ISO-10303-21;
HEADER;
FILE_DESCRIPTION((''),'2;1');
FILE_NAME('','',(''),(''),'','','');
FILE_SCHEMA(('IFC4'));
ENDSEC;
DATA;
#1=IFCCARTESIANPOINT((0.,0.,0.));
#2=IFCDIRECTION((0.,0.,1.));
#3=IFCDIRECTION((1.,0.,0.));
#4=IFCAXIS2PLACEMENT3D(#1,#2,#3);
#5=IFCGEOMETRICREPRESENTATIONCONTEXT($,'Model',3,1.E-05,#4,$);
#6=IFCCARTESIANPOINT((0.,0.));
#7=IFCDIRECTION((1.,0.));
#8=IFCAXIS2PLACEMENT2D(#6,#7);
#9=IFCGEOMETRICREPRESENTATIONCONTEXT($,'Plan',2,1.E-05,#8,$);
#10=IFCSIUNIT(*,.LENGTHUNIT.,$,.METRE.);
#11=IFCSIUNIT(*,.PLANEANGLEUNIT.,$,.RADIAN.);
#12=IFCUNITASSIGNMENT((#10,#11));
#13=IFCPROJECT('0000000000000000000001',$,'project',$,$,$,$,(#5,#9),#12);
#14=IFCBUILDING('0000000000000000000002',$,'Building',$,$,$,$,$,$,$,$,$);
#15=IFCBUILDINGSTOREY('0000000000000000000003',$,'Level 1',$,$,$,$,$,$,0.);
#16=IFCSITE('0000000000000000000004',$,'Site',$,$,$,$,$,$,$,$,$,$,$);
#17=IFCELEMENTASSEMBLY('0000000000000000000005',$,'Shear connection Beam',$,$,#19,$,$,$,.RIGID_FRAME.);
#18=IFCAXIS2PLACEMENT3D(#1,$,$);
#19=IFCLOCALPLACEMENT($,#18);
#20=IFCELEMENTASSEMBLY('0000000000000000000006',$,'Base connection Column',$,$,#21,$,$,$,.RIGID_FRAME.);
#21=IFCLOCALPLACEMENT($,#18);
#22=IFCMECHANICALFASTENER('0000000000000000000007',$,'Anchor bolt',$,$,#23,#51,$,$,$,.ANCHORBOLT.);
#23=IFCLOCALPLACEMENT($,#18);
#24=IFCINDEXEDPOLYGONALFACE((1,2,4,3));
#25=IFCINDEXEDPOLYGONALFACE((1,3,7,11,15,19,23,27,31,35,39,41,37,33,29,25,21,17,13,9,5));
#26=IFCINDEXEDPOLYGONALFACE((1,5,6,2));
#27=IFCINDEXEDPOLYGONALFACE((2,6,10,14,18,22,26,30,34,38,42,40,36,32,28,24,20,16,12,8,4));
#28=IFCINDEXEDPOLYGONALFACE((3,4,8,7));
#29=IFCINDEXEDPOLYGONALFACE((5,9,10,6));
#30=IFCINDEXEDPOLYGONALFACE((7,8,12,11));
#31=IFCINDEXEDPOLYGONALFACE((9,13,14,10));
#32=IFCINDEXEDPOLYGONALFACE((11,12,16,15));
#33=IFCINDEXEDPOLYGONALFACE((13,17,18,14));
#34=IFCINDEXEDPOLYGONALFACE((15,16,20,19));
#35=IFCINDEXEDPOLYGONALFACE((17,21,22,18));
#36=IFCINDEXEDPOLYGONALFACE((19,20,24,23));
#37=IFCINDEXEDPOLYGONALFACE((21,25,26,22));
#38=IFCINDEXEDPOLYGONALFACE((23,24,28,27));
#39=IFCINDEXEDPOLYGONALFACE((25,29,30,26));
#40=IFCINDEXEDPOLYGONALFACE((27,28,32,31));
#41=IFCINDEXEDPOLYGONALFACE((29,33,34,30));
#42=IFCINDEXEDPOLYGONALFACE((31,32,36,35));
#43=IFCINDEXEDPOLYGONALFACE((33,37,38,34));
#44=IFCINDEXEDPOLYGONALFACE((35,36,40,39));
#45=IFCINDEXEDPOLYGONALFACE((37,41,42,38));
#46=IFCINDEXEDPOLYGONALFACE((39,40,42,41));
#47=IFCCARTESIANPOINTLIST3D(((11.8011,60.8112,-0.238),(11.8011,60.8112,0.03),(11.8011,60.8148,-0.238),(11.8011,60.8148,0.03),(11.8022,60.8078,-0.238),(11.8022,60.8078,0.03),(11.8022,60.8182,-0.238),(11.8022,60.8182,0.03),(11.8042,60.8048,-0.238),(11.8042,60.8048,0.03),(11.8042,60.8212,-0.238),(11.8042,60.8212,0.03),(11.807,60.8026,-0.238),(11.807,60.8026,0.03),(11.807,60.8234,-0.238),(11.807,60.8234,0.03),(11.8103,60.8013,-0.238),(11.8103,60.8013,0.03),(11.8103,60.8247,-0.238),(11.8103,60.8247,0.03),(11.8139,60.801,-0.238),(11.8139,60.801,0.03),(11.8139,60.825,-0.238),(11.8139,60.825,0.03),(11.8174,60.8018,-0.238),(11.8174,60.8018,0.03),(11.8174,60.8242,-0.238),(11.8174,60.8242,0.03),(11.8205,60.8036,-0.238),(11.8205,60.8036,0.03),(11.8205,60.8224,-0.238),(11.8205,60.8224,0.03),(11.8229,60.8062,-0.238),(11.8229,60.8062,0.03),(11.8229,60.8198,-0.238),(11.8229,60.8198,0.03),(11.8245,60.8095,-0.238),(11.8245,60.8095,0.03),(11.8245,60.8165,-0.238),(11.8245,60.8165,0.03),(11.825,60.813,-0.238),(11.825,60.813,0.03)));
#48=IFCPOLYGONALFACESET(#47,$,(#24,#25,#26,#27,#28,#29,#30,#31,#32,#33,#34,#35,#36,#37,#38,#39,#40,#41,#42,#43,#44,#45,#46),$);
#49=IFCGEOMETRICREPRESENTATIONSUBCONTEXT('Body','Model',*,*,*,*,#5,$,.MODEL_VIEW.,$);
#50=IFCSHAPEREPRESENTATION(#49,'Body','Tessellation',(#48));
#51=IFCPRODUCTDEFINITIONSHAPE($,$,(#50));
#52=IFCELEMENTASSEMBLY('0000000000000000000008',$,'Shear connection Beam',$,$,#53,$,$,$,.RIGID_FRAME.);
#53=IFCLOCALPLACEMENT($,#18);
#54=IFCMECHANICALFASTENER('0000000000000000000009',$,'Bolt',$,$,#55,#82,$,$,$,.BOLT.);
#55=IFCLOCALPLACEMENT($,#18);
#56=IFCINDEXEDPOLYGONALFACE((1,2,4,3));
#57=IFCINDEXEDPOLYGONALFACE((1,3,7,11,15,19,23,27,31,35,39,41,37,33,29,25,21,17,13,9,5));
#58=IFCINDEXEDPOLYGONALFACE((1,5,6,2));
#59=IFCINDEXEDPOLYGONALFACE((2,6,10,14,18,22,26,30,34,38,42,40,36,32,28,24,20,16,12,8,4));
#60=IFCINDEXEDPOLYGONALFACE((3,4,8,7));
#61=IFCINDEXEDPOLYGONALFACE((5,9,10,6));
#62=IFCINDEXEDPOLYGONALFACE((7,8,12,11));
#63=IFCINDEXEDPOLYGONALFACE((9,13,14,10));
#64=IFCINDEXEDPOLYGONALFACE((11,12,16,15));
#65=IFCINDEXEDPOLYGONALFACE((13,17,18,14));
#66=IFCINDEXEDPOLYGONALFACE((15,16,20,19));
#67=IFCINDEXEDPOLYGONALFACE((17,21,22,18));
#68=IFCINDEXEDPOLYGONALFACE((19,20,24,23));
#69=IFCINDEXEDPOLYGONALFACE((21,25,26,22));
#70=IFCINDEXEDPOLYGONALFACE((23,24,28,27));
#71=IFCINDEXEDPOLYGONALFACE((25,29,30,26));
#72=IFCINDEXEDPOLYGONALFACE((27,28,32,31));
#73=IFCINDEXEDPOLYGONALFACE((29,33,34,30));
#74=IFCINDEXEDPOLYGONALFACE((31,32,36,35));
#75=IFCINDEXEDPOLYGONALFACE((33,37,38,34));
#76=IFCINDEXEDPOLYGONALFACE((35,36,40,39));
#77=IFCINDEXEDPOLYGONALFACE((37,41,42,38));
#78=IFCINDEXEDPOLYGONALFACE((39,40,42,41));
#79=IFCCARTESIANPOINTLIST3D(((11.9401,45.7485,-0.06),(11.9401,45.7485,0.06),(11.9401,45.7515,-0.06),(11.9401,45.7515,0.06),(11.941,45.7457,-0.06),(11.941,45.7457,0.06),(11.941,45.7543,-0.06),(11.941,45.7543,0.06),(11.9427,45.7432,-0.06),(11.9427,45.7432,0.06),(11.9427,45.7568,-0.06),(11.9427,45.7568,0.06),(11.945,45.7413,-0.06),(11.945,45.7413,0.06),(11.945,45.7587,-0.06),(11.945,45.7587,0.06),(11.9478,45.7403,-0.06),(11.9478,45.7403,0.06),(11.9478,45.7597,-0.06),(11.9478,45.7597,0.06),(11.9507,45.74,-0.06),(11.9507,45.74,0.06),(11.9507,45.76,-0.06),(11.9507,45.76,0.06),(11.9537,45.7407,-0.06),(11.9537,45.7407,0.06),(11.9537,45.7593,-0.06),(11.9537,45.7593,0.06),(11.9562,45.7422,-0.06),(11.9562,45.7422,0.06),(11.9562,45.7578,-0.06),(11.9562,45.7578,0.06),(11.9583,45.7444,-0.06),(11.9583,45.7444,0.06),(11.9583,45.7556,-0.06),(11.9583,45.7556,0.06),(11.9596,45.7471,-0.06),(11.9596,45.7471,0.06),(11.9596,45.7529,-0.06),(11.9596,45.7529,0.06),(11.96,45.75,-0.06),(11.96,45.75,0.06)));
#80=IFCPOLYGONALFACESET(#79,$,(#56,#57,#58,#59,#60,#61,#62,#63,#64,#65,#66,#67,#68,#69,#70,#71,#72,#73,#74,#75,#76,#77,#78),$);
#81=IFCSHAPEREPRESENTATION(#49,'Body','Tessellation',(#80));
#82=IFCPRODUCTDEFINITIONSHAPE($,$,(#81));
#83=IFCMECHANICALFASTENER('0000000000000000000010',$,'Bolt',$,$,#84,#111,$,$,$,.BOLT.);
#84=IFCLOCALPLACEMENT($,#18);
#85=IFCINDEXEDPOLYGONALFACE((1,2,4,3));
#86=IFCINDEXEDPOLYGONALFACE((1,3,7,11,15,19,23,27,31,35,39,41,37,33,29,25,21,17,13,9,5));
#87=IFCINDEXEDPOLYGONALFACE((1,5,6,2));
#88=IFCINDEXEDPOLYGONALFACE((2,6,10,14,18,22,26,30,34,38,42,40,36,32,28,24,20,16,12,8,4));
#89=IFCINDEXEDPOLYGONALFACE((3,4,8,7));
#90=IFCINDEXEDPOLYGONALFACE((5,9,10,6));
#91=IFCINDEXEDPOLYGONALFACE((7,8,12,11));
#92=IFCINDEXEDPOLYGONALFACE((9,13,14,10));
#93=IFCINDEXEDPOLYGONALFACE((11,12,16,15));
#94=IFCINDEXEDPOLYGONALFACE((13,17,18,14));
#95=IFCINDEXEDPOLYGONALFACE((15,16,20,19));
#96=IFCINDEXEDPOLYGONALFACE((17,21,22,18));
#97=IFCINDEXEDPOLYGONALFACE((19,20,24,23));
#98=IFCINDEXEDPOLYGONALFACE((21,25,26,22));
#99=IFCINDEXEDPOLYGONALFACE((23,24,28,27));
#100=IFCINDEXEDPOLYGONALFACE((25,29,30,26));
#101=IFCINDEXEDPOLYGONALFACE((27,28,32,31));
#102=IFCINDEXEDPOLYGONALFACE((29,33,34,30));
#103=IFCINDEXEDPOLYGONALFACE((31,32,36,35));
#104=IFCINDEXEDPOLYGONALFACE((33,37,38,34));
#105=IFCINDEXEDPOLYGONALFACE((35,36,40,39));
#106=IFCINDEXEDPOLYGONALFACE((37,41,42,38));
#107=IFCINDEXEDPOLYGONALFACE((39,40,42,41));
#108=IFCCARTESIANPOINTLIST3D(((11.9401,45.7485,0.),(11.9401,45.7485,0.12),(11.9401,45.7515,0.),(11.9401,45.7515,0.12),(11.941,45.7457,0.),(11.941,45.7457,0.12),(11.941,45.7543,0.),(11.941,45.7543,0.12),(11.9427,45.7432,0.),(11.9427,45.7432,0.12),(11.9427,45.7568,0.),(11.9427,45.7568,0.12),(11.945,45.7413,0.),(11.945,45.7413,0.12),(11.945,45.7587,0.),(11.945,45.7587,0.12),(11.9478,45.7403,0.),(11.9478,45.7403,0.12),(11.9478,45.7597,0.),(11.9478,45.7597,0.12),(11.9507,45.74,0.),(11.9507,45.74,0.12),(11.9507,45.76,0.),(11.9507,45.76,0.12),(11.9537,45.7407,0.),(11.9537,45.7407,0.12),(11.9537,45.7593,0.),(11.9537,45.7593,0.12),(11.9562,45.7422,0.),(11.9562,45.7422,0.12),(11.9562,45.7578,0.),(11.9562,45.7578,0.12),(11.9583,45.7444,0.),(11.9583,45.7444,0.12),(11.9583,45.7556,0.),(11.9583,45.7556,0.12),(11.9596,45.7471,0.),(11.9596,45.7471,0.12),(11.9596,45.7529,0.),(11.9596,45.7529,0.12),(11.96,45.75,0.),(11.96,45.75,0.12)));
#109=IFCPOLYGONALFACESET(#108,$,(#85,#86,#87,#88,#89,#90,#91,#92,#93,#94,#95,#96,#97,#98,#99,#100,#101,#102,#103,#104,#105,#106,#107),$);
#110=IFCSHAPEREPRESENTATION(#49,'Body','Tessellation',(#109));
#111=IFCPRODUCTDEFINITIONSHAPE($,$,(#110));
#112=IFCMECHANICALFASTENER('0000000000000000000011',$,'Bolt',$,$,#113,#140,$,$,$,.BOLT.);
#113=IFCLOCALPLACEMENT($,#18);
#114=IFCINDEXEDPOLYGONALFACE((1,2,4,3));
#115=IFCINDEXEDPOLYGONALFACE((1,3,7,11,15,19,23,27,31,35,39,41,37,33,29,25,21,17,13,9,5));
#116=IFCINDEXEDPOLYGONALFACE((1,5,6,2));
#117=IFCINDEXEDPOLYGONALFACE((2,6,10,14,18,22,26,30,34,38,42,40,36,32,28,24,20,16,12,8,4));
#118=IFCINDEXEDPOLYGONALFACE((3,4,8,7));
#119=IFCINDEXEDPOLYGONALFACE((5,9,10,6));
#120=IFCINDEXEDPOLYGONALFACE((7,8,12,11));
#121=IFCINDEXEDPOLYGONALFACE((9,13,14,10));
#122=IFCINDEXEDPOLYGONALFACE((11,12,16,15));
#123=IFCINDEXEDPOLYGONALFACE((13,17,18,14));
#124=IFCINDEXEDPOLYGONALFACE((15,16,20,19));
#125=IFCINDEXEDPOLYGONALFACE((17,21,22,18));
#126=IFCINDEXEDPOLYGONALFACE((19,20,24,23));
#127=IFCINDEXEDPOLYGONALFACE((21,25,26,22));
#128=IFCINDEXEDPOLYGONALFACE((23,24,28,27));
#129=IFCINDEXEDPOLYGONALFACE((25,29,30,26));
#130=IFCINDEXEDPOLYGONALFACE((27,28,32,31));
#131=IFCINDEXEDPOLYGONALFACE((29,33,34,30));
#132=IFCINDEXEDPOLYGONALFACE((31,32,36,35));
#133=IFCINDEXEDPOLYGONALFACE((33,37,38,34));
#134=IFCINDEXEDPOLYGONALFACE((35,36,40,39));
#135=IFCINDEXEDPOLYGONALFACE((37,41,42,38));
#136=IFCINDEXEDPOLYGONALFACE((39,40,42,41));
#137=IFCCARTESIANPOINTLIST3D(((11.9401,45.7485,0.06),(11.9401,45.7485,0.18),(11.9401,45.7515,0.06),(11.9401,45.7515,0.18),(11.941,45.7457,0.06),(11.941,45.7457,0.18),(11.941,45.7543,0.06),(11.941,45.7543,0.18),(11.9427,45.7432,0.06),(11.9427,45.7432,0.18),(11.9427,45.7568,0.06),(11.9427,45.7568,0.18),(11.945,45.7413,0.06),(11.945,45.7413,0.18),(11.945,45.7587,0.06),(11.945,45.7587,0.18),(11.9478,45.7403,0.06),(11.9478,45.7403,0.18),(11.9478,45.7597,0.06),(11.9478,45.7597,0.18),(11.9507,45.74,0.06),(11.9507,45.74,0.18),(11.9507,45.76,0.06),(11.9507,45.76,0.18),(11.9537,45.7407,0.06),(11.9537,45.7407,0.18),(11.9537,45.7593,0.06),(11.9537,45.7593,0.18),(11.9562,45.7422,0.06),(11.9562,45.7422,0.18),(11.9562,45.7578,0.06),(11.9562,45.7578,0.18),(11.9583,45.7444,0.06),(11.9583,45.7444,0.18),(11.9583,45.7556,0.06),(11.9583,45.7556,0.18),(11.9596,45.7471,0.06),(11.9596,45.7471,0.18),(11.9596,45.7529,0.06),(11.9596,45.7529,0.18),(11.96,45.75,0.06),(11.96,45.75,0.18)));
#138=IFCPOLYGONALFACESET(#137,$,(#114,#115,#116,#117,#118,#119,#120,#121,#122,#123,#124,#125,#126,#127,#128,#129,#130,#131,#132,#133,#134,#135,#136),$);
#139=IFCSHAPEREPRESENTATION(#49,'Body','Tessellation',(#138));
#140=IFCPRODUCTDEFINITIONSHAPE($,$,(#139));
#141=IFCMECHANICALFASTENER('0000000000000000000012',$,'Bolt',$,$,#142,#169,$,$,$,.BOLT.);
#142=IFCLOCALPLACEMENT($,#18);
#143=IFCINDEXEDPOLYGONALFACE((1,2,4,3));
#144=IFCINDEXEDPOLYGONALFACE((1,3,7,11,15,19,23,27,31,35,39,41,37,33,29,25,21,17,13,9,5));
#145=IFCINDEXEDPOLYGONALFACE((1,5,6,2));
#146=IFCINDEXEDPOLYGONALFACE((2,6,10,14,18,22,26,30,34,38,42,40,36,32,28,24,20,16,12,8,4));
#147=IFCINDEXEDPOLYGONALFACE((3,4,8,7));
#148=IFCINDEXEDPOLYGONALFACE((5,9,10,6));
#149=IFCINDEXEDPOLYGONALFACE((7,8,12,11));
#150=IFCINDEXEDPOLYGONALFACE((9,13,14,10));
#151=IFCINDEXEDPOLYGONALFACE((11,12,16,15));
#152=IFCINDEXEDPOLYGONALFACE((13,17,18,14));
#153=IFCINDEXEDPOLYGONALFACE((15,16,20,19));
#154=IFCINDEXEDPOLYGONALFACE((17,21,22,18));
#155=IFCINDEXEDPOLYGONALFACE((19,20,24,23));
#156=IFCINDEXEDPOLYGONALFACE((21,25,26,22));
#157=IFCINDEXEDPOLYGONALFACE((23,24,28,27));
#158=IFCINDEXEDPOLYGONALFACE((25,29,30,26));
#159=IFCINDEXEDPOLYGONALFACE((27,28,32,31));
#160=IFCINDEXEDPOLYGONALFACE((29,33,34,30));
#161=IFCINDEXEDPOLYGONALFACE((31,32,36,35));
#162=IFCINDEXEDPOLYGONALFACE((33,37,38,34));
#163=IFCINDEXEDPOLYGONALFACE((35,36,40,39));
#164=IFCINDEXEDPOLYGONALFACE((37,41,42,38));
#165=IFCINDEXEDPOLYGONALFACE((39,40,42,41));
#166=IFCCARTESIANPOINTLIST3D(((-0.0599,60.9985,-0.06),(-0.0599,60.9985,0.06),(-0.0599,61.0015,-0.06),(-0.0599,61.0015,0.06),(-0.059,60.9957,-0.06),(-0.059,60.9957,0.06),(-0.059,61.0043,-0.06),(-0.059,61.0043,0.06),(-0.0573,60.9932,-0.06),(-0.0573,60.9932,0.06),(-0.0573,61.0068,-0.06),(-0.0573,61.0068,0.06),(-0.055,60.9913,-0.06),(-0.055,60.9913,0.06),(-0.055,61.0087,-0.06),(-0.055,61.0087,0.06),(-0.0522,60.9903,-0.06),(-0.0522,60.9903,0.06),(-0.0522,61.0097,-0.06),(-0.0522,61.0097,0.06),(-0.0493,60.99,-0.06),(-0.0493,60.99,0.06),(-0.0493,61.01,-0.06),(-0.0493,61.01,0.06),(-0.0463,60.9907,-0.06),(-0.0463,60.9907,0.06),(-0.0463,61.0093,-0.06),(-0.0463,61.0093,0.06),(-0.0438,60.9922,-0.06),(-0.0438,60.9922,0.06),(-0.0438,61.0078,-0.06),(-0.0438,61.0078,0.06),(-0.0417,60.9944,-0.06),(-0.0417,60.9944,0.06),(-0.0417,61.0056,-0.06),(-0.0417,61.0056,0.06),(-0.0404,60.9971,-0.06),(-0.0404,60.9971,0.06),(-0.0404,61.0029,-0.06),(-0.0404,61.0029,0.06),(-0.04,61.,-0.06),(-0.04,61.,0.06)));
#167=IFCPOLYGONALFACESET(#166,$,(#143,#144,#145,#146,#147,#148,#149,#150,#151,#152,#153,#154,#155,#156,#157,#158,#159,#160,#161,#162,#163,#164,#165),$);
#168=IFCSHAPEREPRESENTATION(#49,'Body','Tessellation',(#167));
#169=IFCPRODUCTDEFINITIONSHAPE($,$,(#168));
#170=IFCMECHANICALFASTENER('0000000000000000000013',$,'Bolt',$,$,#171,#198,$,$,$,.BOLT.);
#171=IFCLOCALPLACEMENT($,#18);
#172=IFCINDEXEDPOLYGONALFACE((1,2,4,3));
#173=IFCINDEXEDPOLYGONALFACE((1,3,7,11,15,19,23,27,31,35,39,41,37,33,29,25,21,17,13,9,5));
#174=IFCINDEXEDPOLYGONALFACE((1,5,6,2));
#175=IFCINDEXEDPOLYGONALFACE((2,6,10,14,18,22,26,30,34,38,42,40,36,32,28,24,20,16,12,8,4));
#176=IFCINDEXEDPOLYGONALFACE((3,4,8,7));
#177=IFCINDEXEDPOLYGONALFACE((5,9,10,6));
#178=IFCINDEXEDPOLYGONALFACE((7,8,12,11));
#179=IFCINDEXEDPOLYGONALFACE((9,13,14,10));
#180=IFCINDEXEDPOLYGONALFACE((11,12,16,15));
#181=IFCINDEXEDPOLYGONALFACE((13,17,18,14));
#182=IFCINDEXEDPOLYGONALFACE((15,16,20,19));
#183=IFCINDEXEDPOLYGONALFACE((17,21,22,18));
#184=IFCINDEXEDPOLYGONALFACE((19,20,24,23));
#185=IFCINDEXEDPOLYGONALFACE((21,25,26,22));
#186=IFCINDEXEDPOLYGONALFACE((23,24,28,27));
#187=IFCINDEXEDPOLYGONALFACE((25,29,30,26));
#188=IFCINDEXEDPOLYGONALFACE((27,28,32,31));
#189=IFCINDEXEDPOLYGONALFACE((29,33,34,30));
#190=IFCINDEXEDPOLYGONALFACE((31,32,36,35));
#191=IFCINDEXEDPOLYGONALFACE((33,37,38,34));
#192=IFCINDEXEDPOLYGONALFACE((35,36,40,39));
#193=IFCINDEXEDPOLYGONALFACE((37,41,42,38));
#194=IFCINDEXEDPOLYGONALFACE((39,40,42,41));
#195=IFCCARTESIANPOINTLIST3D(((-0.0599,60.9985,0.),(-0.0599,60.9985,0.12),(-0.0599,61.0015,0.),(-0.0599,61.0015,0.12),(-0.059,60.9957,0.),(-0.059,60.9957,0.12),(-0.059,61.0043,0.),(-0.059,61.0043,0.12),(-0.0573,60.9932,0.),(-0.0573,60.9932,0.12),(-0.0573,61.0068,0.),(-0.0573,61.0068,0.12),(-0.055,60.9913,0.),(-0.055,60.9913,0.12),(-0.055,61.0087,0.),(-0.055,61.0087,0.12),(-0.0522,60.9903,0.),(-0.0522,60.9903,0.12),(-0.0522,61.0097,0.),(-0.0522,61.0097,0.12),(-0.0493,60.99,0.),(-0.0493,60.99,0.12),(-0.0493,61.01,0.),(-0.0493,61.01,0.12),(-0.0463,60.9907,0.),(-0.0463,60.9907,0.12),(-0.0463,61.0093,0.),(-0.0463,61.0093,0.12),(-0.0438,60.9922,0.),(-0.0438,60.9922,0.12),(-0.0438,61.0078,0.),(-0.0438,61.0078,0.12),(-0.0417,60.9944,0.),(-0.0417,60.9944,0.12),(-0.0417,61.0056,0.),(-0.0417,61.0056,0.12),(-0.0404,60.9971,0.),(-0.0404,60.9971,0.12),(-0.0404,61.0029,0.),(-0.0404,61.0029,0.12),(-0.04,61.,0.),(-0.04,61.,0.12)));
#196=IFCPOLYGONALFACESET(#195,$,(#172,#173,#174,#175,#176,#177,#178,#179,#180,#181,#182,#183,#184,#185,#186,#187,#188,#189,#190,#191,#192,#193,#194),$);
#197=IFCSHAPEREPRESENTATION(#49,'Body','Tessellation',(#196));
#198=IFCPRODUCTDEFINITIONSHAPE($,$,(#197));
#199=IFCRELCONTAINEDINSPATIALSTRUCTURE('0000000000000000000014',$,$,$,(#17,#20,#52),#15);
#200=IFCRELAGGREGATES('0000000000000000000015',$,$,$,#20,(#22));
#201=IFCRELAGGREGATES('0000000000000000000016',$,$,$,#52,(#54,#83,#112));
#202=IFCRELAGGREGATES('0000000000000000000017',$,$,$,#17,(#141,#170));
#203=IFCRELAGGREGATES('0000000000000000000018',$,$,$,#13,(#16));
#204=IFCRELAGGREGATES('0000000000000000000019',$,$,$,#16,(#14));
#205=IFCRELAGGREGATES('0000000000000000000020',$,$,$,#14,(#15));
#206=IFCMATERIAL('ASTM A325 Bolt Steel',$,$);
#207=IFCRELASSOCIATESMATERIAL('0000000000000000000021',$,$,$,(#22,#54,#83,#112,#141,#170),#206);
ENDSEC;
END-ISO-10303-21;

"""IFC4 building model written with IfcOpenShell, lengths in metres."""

from ifc_helpers import new_model, si_unit, frame, origin_with_axes, origin_2d, origin_2d_with_axis, place, context, subcontext, project, spatial, circle, extrude, material, element, aggregate, save


model = new_model("IFC4")

# Units and contexts
model_context = context("Model", 3, precision=1e-05, world=origin_with_axes())
plan_context = context("Plan", 2, precision=1e-05, world=origin_2d_with_axis())
body_context = subcontext(model_context, "Body", "Model", "MODEL_VIEW")
ifc_project = project(units=[si_unit("LENGTHUNIT", "METRE"), si_unit("PLANEANGLEUNIT", "RADIAN")], contexts=[model_context, plan_context])

# Site, building, storey
site = spatial("IfcSite", under=ifc_project, Name="Site")
building = spatial("IfcBuilding", under=site, Name="Building")
storey = spatial("IfcBuildingStorey", under=building, Name="Level 1", Elevation=0.0)

# Element assembly
assembly_1 = element("IfcElementAssembly", 1, inside=storey, Name="Shear connection Beam", PredefinedType="RIGID_FRAME")

# Shared definitions
ifc_material_1 = material(Name="ASTM A325 Bolt Steel")

# Element assemblies, mechanical fasteners
assembly_2 = element("IfcElementAssembly", 2, inside=storey, Name="Base connection Column", PredefinedType="RIGID_FRAME")
mechanical_fastener_1_placement = place(None, frame((11.813, 60.813, -0.238), z_axis=(0.0, 0.0, 1.0), x_axis=(1.0, 0.0, 0.0)))
mechanical_fastener_1 = element("IfcMechanicalFastener", 3, at=mechanical_fastener_1_placement, material=ifc_material_1, Name="Anchor bolt", PredefinedType="ANCHORBOLT", context=body_context, shape_type="SweptSolid", body=[
    extrude(circle(Radius=0.012, at=origin_2d()), origin_with_axes(), (0.0, 0.0, 1.0), 0.268),
])
aggregate(assembly_2, [mechanical_fastener_1])
assembly_3 = element("IfcElementAssembly", 4, inside=storey, Name="Shear connection Beam", PredefinedType="RIGID_FRAME")
mechanical_fastener_2_placement = place(None, frame((11.95, 45.75, -0.06), z_axis=(0.0, 0.0, 1.0), x_axis=(1.0, 0.0, 0.0)))
mechanical_fastener_2 = element("IfcMechanicalFastener", 5, at=mechanical_fastener_2_placement, material=ifc_material_1, Name="Bolt", PredefinedType="BOLT", context=body_context, shape_type="SweptSolid", body=[
    extrude(circle(Radius=0.01, at=origin_2d()), origin_with_axes(), (0.0, 0.0, 1.0), 0.12),
])
mechanical_fastener_3_placement = place(None, frame((11.95, 45.75, 0.0), z_axis=(0.0, 0.0, 1.0), x_axis=(1.0, 0.0, 0.0)))
mechanical_fastener_3 = element("IfcMechanicalFastener", 6, at=mechanical_fastener_3_placement, material=ifc_material_1, Name="Bolt", PredefinedType="BOLT", context=body_context, shape_type="SweptSolid", body=[
    extrude(circle(Radius=0.01, at=origin_2d()), origin_with_axes(), (0.0, 0.0, 1.0), 0.12),
])
mechanical_fastener_4_placement = place(None, frame((11.95, 45.75, 0.06), z_axis=(0.0, 0.0, 1.0), x_axis=(1.0, 0.0, 0.0)))
mechanical_fastener_4 = element("IfcMechanicalFastener", 7, at=mechanical_fastener_4_placement, material=ifc_material_1, Name="Bolt", PredefinedType="BOLT", context=body_context, shape_type="SweptSolid", body=[
    extrude(circle(Radius=0.01, at=origin_2d()), origin_with_axes(), (0.0, 0.0, 1.0), 0.12),
])
aggregate(assembly_3, [mechanical_fastener_2, mechanical_fastener_3, mechanical_fastener_4])

# Mechanical fasteners
mechanical_fastener_5_placement = place(None, frame((-0.05, 61.0, -0.06), z_axis=(0.0, 0.0, 1.0), x_axis=(1.0, 0.0, 0.0)))
mechanical_fastener_5 = element("IfcMechanicalFastener", 8, at=mechanical_fastener_5_placement, material=ifc_material_1, Name="Bolt", PredefinedType="BOLT", context=body_context, shape_type="SweptSolid", body=[
    extrude(circle(Radius=0.01, at=origin_2d()), origin_with_axes(), (0.0, 0.0, 1.0), 0.12),
])
mechanical_fastener_6_placement = place(None, frame((-0.05, 61.0, 0.0), z_axis=(0.0, 0.0, 1.0), x_axis=(1.0, 0.0, 0.0)))
mechanical_fastener_6 = element("IfcMechanicalFastener", 9, at=mechanical_fastener_6_placement, material=ifc_material_1, Name="Bolt", PredefinedType="BOLT", context=body_context, shape_type="SweptSolid", body=[
    extrude(circle(Radius=0.01, at=origin_2d()), origin_with_axes(), (0.0, 0.0, 1.0), 0.12),
])
aggregate(assembly_1, [mechanical_fastener_5, mechanical_fastener_6])

save(model, "model.ifc")
